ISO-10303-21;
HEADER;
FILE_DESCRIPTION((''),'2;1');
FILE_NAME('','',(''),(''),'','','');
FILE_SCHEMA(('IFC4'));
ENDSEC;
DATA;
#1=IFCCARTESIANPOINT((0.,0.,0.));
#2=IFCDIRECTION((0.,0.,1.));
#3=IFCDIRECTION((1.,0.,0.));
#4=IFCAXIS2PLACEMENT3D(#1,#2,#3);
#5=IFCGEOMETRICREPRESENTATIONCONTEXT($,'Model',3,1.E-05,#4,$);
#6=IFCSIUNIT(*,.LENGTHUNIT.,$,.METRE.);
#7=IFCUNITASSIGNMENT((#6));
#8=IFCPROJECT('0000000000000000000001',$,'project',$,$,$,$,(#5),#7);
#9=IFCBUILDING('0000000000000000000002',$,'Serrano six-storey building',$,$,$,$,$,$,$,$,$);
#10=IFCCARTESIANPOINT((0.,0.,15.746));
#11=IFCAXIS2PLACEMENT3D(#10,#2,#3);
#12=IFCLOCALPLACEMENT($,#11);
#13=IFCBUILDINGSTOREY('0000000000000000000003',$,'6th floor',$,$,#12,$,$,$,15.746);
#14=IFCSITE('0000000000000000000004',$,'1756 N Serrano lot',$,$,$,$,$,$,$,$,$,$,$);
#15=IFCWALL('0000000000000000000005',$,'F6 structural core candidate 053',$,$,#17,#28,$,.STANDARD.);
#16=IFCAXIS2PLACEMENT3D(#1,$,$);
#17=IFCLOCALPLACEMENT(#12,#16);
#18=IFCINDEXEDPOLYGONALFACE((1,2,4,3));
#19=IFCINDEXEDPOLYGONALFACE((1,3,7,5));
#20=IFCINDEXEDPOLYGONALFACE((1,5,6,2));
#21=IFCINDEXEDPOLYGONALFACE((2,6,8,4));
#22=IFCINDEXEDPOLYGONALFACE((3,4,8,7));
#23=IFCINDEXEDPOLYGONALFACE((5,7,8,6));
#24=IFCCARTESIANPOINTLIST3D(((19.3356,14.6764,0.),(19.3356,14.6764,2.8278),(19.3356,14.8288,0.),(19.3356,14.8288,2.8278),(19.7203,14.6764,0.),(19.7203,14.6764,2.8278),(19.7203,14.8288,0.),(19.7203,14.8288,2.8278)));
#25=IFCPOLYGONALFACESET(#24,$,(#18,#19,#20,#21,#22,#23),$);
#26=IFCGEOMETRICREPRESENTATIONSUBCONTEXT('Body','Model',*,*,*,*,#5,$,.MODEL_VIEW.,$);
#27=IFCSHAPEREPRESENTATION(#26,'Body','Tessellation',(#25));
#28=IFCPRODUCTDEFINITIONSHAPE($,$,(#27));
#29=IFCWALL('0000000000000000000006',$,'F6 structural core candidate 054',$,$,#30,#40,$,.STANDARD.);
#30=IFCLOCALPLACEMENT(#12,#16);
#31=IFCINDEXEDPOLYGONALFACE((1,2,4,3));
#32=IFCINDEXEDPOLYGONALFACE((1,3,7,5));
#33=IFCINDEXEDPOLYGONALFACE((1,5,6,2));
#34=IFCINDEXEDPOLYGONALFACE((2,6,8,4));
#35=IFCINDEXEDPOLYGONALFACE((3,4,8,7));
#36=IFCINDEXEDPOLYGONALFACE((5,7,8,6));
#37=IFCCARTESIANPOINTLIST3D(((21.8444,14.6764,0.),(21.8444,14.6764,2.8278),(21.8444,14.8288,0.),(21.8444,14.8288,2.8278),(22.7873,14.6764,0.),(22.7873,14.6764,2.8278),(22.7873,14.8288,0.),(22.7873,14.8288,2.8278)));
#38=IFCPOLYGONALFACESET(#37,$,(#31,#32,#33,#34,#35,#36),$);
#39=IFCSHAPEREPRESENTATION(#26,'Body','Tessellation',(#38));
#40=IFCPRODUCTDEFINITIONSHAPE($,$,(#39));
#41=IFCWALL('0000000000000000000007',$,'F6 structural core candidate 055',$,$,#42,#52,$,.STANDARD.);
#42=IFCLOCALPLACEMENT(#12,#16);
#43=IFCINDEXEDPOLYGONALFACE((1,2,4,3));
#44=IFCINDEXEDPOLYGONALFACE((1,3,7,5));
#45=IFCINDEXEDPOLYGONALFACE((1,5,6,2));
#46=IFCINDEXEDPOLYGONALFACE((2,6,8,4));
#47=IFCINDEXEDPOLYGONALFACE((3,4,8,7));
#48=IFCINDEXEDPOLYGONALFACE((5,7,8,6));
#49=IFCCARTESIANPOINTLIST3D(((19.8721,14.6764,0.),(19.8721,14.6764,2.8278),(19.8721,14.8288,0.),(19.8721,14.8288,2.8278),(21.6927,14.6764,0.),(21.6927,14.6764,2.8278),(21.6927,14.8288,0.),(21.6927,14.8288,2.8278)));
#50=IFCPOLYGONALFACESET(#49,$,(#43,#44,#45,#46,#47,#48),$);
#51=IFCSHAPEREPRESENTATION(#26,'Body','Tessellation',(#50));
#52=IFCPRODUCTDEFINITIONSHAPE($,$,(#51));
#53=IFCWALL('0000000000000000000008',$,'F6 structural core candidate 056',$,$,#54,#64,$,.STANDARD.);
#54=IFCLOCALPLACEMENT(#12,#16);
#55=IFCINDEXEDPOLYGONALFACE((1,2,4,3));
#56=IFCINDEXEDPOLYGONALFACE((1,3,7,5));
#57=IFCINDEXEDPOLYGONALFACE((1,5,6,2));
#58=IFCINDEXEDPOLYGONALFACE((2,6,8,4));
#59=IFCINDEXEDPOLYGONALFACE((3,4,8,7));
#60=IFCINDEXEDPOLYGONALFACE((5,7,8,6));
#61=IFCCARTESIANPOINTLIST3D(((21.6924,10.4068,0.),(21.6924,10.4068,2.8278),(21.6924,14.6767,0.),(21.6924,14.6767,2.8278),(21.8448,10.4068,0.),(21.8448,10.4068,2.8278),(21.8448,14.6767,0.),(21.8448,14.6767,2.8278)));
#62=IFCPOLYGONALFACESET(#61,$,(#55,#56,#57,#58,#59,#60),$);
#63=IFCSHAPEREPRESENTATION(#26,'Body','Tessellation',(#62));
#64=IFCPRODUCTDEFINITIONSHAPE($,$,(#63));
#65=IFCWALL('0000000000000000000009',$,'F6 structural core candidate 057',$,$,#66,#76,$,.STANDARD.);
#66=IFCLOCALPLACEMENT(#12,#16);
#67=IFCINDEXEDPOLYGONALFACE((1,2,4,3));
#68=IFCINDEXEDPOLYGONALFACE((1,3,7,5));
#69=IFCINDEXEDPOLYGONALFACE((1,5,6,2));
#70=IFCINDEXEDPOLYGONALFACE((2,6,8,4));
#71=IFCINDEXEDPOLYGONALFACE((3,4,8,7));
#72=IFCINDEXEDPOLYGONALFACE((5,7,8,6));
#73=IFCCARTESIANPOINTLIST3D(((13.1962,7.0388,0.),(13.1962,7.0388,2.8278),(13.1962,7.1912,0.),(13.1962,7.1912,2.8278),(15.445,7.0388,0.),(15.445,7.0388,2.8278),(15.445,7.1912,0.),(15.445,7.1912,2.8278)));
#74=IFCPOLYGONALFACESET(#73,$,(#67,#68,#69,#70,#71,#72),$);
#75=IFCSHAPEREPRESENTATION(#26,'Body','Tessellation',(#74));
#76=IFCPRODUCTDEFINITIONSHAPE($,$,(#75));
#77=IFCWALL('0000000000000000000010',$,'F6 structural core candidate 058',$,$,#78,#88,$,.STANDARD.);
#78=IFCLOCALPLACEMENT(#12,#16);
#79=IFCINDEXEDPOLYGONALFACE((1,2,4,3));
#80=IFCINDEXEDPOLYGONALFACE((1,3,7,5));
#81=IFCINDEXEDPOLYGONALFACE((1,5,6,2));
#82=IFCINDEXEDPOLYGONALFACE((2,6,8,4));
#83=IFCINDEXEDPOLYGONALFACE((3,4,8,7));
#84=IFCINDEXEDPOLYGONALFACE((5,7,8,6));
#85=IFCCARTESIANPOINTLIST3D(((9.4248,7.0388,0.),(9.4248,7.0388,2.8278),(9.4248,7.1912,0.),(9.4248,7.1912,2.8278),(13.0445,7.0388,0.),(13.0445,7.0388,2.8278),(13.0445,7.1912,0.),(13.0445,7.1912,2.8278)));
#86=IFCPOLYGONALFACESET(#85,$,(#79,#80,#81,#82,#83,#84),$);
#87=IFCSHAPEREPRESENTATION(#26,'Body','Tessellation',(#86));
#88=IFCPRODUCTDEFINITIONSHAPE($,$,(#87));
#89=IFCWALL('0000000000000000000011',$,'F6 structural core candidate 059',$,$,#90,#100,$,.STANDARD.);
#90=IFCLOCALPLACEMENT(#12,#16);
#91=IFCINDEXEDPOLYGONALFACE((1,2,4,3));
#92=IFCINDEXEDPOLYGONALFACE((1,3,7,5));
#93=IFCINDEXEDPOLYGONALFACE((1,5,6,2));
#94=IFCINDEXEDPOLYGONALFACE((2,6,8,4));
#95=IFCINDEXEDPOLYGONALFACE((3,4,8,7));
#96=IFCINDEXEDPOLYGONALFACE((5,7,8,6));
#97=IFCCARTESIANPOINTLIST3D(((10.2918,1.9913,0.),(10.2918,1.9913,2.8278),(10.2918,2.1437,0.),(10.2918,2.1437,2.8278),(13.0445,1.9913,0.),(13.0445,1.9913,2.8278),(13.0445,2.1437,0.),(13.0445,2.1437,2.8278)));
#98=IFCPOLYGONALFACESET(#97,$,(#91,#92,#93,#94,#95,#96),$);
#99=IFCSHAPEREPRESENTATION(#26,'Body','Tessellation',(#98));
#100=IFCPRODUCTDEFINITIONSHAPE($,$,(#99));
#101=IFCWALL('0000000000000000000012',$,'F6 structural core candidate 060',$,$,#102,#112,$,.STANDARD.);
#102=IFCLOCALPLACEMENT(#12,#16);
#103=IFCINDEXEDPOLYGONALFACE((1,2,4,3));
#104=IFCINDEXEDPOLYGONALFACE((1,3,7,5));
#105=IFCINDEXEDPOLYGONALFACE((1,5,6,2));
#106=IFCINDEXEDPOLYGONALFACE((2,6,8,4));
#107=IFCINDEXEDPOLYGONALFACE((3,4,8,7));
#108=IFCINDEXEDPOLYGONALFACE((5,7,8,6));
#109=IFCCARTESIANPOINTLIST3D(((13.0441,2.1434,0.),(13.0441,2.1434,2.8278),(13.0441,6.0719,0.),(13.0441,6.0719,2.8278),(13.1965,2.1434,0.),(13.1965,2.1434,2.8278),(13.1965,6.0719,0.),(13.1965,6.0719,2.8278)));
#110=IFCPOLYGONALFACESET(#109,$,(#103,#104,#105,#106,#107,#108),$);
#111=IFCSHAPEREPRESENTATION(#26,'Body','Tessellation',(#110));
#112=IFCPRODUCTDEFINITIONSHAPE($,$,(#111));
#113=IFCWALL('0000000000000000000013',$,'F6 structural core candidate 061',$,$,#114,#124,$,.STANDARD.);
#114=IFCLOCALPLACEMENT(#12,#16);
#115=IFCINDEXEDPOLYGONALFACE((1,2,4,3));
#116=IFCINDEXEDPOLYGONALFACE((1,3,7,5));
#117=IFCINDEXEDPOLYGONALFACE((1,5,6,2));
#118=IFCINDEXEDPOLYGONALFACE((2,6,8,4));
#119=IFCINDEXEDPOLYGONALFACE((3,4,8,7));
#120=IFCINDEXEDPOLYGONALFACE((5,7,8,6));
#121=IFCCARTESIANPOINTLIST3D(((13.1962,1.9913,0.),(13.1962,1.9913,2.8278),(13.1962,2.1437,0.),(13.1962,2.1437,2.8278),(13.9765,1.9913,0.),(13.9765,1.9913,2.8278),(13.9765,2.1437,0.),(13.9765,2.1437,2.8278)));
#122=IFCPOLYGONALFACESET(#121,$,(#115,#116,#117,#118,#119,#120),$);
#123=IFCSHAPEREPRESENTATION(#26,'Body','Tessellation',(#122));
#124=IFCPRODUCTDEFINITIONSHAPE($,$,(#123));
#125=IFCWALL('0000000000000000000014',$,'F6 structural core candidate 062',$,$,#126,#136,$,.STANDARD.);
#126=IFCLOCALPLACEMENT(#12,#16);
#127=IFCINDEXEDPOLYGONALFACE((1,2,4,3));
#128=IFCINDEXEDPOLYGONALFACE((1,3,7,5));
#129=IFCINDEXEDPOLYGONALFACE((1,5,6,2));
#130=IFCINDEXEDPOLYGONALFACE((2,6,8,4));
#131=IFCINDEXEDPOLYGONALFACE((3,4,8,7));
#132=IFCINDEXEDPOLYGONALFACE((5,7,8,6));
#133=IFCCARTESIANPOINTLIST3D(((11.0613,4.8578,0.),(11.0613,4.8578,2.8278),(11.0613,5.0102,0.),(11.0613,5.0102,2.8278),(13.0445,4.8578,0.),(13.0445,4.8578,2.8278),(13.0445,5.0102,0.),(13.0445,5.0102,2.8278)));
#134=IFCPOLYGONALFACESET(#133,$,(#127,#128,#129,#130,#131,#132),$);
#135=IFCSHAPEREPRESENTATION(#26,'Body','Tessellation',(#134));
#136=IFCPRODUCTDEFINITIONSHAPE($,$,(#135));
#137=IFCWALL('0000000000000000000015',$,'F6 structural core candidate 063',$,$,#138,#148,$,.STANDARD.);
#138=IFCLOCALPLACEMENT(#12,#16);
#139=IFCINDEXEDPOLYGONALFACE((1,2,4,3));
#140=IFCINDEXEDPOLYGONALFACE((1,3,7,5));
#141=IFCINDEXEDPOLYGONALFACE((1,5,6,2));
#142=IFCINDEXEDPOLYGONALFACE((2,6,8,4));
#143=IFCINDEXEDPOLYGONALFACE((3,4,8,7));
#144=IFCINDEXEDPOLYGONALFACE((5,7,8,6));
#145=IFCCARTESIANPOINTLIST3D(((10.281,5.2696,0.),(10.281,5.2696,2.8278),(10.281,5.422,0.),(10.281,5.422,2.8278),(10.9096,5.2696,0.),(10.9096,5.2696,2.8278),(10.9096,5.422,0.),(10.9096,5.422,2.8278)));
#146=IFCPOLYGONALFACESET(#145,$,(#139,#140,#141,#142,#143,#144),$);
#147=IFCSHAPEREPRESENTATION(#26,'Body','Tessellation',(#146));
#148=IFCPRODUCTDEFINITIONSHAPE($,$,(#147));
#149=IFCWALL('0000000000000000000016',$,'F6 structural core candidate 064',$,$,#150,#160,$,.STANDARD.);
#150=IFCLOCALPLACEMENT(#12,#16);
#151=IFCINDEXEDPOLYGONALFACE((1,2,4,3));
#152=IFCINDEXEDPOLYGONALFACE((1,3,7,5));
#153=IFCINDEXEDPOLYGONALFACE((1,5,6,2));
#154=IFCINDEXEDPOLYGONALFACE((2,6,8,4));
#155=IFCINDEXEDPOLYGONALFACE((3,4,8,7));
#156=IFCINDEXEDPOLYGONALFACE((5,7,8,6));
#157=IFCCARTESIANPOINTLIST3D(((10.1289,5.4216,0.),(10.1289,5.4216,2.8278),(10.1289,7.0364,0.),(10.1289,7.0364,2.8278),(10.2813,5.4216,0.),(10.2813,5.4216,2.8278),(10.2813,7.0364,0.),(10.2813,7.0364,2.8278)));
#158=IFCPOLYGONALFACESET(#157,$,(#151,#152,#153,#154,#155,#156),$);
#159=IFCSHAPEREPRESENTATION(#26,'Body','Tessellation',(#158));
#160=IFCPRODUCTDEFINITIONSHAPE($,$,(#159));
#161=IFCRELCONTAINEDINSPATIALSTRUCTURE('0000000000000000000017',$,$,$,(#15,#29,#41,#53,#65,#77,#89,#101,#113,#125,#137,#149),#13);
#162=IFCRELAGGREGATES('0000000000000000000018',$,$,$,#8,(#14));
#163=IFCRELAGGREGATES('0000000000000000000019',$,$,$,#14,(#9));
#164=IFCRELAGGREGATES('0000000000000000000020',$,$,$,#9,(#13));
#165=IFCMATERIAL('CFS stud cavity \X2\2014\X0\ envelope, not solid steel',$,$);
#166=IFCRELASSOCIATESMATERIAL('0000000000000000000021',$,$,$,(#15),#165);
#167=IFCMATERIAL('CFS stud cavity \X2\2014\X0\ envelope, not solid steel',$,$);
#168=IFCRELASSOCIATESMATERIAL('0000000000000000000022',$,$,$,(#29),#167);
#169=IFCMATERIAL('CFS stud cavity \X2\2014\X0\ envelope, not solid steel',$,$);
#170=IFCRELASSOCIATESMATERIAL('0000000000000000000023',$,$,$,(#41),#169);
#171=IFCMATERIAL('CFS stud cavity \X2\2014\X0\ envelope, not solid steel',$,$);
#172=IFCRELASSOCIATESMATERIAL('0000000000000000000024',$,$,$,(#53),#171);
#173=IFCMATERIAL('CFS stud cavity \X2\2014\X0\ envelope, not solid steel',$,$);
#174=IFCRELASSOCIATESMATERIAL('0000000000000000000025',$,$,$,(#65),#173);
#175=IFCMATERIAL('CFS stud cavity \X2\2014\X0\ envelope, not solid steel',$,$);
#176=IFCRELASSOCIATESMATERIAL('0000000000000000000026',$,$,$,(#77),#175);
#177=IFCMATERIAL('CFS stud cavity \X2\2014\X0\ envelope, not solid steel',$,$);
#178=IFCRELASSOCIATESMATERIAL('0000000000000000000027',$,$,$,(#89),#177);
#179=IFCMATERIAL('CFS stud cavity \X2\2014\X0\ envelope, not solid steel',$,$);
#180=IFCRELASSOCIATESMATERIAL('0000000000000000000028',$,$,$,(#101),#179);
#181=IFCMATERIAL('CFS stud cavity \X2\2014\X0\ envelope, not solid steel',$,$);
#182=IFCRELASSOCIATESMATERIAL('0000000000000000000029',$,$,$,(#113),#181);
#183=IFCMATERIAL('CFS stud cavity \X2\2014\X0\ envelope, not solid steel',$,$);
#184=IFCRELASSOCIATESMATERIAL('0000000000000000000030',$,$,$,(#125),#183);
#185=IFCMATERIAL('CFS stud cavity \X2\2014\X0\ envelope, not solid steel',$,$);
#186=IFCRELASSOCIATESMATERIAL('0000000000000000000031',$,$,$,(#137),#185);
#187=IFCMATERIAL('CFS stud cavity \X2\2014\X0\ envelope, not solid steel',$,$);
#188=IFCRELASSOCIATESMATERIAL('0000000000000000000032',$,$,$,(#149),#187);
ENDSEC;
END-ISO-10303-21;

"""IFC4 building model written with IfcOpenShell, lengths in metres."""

from ifc_helpers import new_model, si_unit, frame, origin_with_axes, place, context, subcontext, project, spatial, polyline, outline, extrude, material, element, save


model = new_model("IFC4")

# Units and contexts
model_context = context("Model", 3, precision=1e-05, world=origin_with_axes())
body_context = subcontext(model_context, "Body", "Model", "MODEL_VIEW")
ifc_project = project(units=[si_unit("LENGTHUNIT", "METRE")], contexts=[model_context])

# Site, building, storey
site = spatial("IfcSite", under=ifc_project, Name="1756 N Serrano lot")
building = spatial("IfcBuilding", under=site, Name="Serrano six-storey building")
storey_placement = place(None, frame((0.0, 0.0, 15.746), z_axis=(0.0, 0.0, 1.0), x_axis=(1.0, 0.0, 0.0)))
storey = spatial("IfcBuildingStorey", under=building, at=storey_placement, Name="6th floor", Elevation=15.746)

# Walls
ifc_material_1 = material(Name="CFS stud cavity — envelope, not solid steel")
wall_1_placement = place(storey_placement, frame((0.0, 0.0, -15.746), z_axis=(0.0, 0.0, 1.0), x_axis=(1.0, 0.0, 0.0)))
element("IfcWall", 1, at=wall_1_placement, inside=storey, material=ifc_material_1, Name="F6 structural core candidate 053", PredefinedType="STANDARD", context=body_context, shape_type="SweptSolid", body=[
    extrude(outline(polyline([(19.7203, 14.8288), (19.7203, 14.6764), (19.3356, 14.6764), (19.3356, 14.8288), (19.7203, 14.8288)])), frame((0.0, 0.0, 15.746)), (0.0, 0.0, 1.0), 2.8278),
])
ifc_material_2 = material(Name="CFS stud cavity — envelope, not solid steel")
wall_2_placement = place(storey_placement, frame((0.0, 0.0, -15.746), z_axis=(0.0, 0.0, 1.0), x_axis=(1.0, 0.0, 0.0)))
element("IfcWall", 2, at=wall_2_placement, inside=storey, material=ifc_material_2, Name="F6 structural core candidate 054", PredefinedType="STANDARD", context=body_context, shape_type="SweptSolid", body=[
    extrude(outline(polyline([(22.7873, 14.8288), (22.7873, 14.6764), (21.8444, 14.6764), (21.8444, 14.8288), (22.7873, 14.8288)])), frame((0.0, 0.0, 15.746)), (0.0, 0.0, 1.0), 2.8278),
])
ifc_material_3 = material(Name="CFS stud cavity — envelope, not solid steel")
wall_3_placement = place(storey_placement, frame((0.0, 0.0, -15.746), z_axis=(0.0, 0.0, 1.0), x_axis=(1.0, 0.0, 0.0)))
element("IfcWall", 3, at=wall_3_placement, inside=storey, material=ifc_material_3, Name="F6 structural core candidate 055", PredefinedType="STANDARD", context=body_context, shape_type="SweptSolid", body=[
    extrude(outline(polyline([(21.6927, 14.8288), (21.6927, 14.6764), (19.8721, 14.6764), (19.8721, 14.8288), (21.6927, 14.8288)])), frame((0.0, 0.0, 15.746)), (0.0, 0.0, 1.0), 2.8278),
])
ifc_material_4 = material(Name="CFS stud cavity — envelope, not solid steel")
wall_4_placement = place(storey_placement, frame((0.0, 0.0, -15.746), z_axis=(0.0, 0.0, 1.0), x_axis=(1.0, 0.0, 0.0)))
element("IfcWall", 4, at=wall_4_placement, inside=storey, material=ifc_material_4, Name="F6 structural core candidate 056", PredefinedType="STANDARD", context=body_context, shape_type="SweptSolid", body=[
    extrude(outline(polyline([(21.8448, 10.4068), (21.6924, 10.4068), (21.6924, 14.6767), (21.8448, 14.6767), (21.8448, 10.4068)])), frame((0.0, 0.0, 15.746)), (0.0, 0.0, 1.0), 2.8278),
])
ifc_material_5 = material(Name="CFS stud cavity — envelope, not solid steel")
wall_5_placement = place(storey_placement, frame((0.0, 0.0, -15.746), z_axis=(0.0, 0.0, 1.0), x_axis=(1.0, 0.0, 0.0)))
element("IfcWall", 5, at=wall_5_placement, inside=storey, material=ifc_material_5, Name="F6 structural core candidate 057", PredefinedType="STANDARD", context=body_context, shape_type="SweptSolid", body=[
    extrude(outline(polyline([(15.445, 7.1912), (15.445, 7.0388), (13.1962, 7.0388), (13.1962, 7.1912), (15.445, 7.1912)])), frame((0.0, 0.0, 15.746)), (0.0, 0.0, 1.0), 2.8278),
])
ifc_material_6 = material(Name="CFS stud cavity — envelope, not solid steel")
wall_6_placement = place(storey_placement, frame((0.0, 0.0, -15.746), z_axis=(0.0, 0.0, 1.0), x_axis=(1.0, 0.0, 0.0)))
element("IfcWall", 6, at=wall_6_placement, inside=storey, material=ifc_material_6, Name="F6 structural core candidate 058", PredefinedType="STANDARD", context=body_context, shape_type="SweptSolid", body=[
    extrude(outline(polyline([(13.0445, 7.1912), (13.0445, 7.0388), (9.4248, 7.0388), (9.4248, 7.1912), (13.0445, 7.1912)])), frame((0.0, 0.0, 15.746)), (0.0, 0.0, 1.0), 2.8278),
])
ifc_material_7 = material(Name="CFS stud cavity — envelope, not solid steel")
wall_7_placement = place(storey_placement, frame((0.0, 0.0, -15.746), z_axis=(0.0, 0.0, 1.0), x_axis=(1.0, 0.0, 0.0)))
element("IfcWall", 7, at=wall_7_placement, inside=storey, material=ifc_material_7, Name="F6 structural core candidate 059", PredefinedType="STANDARD", context=body_context, shape_type="SweptSolid", body=[
    extrude(outline(polyline([(13.0445, 2.1437), (13.0445, 1.9913), (10.2918, 1.9913), (10.2918, 2.1437), (13.0445, 2.1437)])), frame((0.0, 0.0, 15.746)), (0.0, 0.0, 1.0), 2.8278),
])
ifc_material_8 = material(Name="CFS stud cavity — envelope, not solid steel")
wall_8_placement = place(storey_placement, frame((0.0, 0.0, -15.746), z_axis=(0.0, 0.0, 1.0), x_axis=(1.0, 0.0, 0.0)))
element("IfcWall", 8, at=wall_8_placement, inside=storey, material=ifc_material_8, Name="F6 structural core candidate 060", PredefinedType="STANDARD", context=body_context, shape_type="SweptSolid", body=[
    extrude(outline(polyline([(13.1965, 2.1434), (13.0441, 2.1434), (13.0441, 6.0719), (13.1965, 6.0719), (13.1965, 2.1434)])), frame((0.0, 0.0, 15.746)), (0.0, 0.0, 1.0), 2.8278),
])
ifc_material_9 = material(Name="CFS stud cavity — envelope, not solid steel")
wall_9_placement = place(storey_placement, frame((0.0, 0.0, -15.746), z_axis=(0.0, 0.0, 1.0), x_axis=(1.0, 0.0, 0.0)))
element("IfcWall", 9, at=wall_9_placement, inside=storey, material=ifc_material_9, Name="F6 structural core candidate 061", PredefinedType="STANDARD", context=body_context, shape_type="SweptSolid", body=[
    extrude(outline(polyline([(13.9765, 2.1437), (13.9765, 1.9913), (13.1962, 1.9913), (13.1962, 2.1437), (13.9765, 2.1437)])), frame((0.0, 0.0, 15.746)), (0.0, 0.0, 1.0), 2.8278),
])
ifc_material_10 = material(Name="CFS stud cavity — envelope, not solid steel")
wall_10_placement = place(storey_placement, frame((0.0, 0.0, -15.746), z_axis=(0.0, 0.0, 1.0), x_axis=(1.0, 0.0, 0.0)))
element("IfcWall", 10, at=wall_10_placement, inside=storey, material=ifc_material_10, Name="F6 structural core candidate 062", PredefinedType="STANDARD", context=body_context, shape_type="SweptSolid", body=[
    extrude(outline(polyline([(13.0445, 5.0102), (13.0445, 4.8578), (11.0613, 4.8578), (11.0613, 5.0102), (13.0445, 5.0102)])), frame((0.0, 0.0, 15.746)), (0.0, 0.0, 1.0), 2.8278),
])
ifc_material_11 = material(Name="CFS stud cavity — envelope, not solid steel")
wall_11_placement = place(storey_placement, frame((0.0, 0.0, -15.746), z_axis=(0.0, 0.0, 1.0), x_axis=(1.0, 0.0, 0.0)))
element("IfcWall", 11, at=wall_11_placement, inside=storey, material=ifc_material_11, Name="F6 structural core candidate 063", PredefinedType="STANDARD", context=body_context, shape_type="SweptSolid", body=[
    extrude(outline(polyline([(10.9096, 5.422), (10.9096, 5.2696), (10.281, 5.2696), (10.281, 5.422), (10.9096, 5.422)])), frame((0.0, 0.0, 15.746)), (0.0, 0.0, 1.0), 2.8278),
])
ifc_material_12 = material(Name="CFS stud cavity — envelope, not solid steel")
wall_12_placement = place(storey_placement, frame((0.0, 0.0, -15.746), z_axis=(0.0, 0.0, 1.0), x_axis=(1.0, 0.0, 0.0)))
element("IfcWall", 12, at=wall_12_placement, inside=storey, material=ifc_material_12, Name="F6 structural core candidate 064", PredefinedType="STANDARD", context=body_context, shape_type="SweptSolid", body=[
    extrude(outline(polyline([(10.2813, 5.4216), (10.1289, 5.4216), (10.1289, 7.0364), (10.2813, 7.0364), (10.2813, 5.4216)])), frame((0.0, 0.0, 15.746)), (0.0, 0.0, 1.0), 2.8278),
])

save(model, "model.ifc")
